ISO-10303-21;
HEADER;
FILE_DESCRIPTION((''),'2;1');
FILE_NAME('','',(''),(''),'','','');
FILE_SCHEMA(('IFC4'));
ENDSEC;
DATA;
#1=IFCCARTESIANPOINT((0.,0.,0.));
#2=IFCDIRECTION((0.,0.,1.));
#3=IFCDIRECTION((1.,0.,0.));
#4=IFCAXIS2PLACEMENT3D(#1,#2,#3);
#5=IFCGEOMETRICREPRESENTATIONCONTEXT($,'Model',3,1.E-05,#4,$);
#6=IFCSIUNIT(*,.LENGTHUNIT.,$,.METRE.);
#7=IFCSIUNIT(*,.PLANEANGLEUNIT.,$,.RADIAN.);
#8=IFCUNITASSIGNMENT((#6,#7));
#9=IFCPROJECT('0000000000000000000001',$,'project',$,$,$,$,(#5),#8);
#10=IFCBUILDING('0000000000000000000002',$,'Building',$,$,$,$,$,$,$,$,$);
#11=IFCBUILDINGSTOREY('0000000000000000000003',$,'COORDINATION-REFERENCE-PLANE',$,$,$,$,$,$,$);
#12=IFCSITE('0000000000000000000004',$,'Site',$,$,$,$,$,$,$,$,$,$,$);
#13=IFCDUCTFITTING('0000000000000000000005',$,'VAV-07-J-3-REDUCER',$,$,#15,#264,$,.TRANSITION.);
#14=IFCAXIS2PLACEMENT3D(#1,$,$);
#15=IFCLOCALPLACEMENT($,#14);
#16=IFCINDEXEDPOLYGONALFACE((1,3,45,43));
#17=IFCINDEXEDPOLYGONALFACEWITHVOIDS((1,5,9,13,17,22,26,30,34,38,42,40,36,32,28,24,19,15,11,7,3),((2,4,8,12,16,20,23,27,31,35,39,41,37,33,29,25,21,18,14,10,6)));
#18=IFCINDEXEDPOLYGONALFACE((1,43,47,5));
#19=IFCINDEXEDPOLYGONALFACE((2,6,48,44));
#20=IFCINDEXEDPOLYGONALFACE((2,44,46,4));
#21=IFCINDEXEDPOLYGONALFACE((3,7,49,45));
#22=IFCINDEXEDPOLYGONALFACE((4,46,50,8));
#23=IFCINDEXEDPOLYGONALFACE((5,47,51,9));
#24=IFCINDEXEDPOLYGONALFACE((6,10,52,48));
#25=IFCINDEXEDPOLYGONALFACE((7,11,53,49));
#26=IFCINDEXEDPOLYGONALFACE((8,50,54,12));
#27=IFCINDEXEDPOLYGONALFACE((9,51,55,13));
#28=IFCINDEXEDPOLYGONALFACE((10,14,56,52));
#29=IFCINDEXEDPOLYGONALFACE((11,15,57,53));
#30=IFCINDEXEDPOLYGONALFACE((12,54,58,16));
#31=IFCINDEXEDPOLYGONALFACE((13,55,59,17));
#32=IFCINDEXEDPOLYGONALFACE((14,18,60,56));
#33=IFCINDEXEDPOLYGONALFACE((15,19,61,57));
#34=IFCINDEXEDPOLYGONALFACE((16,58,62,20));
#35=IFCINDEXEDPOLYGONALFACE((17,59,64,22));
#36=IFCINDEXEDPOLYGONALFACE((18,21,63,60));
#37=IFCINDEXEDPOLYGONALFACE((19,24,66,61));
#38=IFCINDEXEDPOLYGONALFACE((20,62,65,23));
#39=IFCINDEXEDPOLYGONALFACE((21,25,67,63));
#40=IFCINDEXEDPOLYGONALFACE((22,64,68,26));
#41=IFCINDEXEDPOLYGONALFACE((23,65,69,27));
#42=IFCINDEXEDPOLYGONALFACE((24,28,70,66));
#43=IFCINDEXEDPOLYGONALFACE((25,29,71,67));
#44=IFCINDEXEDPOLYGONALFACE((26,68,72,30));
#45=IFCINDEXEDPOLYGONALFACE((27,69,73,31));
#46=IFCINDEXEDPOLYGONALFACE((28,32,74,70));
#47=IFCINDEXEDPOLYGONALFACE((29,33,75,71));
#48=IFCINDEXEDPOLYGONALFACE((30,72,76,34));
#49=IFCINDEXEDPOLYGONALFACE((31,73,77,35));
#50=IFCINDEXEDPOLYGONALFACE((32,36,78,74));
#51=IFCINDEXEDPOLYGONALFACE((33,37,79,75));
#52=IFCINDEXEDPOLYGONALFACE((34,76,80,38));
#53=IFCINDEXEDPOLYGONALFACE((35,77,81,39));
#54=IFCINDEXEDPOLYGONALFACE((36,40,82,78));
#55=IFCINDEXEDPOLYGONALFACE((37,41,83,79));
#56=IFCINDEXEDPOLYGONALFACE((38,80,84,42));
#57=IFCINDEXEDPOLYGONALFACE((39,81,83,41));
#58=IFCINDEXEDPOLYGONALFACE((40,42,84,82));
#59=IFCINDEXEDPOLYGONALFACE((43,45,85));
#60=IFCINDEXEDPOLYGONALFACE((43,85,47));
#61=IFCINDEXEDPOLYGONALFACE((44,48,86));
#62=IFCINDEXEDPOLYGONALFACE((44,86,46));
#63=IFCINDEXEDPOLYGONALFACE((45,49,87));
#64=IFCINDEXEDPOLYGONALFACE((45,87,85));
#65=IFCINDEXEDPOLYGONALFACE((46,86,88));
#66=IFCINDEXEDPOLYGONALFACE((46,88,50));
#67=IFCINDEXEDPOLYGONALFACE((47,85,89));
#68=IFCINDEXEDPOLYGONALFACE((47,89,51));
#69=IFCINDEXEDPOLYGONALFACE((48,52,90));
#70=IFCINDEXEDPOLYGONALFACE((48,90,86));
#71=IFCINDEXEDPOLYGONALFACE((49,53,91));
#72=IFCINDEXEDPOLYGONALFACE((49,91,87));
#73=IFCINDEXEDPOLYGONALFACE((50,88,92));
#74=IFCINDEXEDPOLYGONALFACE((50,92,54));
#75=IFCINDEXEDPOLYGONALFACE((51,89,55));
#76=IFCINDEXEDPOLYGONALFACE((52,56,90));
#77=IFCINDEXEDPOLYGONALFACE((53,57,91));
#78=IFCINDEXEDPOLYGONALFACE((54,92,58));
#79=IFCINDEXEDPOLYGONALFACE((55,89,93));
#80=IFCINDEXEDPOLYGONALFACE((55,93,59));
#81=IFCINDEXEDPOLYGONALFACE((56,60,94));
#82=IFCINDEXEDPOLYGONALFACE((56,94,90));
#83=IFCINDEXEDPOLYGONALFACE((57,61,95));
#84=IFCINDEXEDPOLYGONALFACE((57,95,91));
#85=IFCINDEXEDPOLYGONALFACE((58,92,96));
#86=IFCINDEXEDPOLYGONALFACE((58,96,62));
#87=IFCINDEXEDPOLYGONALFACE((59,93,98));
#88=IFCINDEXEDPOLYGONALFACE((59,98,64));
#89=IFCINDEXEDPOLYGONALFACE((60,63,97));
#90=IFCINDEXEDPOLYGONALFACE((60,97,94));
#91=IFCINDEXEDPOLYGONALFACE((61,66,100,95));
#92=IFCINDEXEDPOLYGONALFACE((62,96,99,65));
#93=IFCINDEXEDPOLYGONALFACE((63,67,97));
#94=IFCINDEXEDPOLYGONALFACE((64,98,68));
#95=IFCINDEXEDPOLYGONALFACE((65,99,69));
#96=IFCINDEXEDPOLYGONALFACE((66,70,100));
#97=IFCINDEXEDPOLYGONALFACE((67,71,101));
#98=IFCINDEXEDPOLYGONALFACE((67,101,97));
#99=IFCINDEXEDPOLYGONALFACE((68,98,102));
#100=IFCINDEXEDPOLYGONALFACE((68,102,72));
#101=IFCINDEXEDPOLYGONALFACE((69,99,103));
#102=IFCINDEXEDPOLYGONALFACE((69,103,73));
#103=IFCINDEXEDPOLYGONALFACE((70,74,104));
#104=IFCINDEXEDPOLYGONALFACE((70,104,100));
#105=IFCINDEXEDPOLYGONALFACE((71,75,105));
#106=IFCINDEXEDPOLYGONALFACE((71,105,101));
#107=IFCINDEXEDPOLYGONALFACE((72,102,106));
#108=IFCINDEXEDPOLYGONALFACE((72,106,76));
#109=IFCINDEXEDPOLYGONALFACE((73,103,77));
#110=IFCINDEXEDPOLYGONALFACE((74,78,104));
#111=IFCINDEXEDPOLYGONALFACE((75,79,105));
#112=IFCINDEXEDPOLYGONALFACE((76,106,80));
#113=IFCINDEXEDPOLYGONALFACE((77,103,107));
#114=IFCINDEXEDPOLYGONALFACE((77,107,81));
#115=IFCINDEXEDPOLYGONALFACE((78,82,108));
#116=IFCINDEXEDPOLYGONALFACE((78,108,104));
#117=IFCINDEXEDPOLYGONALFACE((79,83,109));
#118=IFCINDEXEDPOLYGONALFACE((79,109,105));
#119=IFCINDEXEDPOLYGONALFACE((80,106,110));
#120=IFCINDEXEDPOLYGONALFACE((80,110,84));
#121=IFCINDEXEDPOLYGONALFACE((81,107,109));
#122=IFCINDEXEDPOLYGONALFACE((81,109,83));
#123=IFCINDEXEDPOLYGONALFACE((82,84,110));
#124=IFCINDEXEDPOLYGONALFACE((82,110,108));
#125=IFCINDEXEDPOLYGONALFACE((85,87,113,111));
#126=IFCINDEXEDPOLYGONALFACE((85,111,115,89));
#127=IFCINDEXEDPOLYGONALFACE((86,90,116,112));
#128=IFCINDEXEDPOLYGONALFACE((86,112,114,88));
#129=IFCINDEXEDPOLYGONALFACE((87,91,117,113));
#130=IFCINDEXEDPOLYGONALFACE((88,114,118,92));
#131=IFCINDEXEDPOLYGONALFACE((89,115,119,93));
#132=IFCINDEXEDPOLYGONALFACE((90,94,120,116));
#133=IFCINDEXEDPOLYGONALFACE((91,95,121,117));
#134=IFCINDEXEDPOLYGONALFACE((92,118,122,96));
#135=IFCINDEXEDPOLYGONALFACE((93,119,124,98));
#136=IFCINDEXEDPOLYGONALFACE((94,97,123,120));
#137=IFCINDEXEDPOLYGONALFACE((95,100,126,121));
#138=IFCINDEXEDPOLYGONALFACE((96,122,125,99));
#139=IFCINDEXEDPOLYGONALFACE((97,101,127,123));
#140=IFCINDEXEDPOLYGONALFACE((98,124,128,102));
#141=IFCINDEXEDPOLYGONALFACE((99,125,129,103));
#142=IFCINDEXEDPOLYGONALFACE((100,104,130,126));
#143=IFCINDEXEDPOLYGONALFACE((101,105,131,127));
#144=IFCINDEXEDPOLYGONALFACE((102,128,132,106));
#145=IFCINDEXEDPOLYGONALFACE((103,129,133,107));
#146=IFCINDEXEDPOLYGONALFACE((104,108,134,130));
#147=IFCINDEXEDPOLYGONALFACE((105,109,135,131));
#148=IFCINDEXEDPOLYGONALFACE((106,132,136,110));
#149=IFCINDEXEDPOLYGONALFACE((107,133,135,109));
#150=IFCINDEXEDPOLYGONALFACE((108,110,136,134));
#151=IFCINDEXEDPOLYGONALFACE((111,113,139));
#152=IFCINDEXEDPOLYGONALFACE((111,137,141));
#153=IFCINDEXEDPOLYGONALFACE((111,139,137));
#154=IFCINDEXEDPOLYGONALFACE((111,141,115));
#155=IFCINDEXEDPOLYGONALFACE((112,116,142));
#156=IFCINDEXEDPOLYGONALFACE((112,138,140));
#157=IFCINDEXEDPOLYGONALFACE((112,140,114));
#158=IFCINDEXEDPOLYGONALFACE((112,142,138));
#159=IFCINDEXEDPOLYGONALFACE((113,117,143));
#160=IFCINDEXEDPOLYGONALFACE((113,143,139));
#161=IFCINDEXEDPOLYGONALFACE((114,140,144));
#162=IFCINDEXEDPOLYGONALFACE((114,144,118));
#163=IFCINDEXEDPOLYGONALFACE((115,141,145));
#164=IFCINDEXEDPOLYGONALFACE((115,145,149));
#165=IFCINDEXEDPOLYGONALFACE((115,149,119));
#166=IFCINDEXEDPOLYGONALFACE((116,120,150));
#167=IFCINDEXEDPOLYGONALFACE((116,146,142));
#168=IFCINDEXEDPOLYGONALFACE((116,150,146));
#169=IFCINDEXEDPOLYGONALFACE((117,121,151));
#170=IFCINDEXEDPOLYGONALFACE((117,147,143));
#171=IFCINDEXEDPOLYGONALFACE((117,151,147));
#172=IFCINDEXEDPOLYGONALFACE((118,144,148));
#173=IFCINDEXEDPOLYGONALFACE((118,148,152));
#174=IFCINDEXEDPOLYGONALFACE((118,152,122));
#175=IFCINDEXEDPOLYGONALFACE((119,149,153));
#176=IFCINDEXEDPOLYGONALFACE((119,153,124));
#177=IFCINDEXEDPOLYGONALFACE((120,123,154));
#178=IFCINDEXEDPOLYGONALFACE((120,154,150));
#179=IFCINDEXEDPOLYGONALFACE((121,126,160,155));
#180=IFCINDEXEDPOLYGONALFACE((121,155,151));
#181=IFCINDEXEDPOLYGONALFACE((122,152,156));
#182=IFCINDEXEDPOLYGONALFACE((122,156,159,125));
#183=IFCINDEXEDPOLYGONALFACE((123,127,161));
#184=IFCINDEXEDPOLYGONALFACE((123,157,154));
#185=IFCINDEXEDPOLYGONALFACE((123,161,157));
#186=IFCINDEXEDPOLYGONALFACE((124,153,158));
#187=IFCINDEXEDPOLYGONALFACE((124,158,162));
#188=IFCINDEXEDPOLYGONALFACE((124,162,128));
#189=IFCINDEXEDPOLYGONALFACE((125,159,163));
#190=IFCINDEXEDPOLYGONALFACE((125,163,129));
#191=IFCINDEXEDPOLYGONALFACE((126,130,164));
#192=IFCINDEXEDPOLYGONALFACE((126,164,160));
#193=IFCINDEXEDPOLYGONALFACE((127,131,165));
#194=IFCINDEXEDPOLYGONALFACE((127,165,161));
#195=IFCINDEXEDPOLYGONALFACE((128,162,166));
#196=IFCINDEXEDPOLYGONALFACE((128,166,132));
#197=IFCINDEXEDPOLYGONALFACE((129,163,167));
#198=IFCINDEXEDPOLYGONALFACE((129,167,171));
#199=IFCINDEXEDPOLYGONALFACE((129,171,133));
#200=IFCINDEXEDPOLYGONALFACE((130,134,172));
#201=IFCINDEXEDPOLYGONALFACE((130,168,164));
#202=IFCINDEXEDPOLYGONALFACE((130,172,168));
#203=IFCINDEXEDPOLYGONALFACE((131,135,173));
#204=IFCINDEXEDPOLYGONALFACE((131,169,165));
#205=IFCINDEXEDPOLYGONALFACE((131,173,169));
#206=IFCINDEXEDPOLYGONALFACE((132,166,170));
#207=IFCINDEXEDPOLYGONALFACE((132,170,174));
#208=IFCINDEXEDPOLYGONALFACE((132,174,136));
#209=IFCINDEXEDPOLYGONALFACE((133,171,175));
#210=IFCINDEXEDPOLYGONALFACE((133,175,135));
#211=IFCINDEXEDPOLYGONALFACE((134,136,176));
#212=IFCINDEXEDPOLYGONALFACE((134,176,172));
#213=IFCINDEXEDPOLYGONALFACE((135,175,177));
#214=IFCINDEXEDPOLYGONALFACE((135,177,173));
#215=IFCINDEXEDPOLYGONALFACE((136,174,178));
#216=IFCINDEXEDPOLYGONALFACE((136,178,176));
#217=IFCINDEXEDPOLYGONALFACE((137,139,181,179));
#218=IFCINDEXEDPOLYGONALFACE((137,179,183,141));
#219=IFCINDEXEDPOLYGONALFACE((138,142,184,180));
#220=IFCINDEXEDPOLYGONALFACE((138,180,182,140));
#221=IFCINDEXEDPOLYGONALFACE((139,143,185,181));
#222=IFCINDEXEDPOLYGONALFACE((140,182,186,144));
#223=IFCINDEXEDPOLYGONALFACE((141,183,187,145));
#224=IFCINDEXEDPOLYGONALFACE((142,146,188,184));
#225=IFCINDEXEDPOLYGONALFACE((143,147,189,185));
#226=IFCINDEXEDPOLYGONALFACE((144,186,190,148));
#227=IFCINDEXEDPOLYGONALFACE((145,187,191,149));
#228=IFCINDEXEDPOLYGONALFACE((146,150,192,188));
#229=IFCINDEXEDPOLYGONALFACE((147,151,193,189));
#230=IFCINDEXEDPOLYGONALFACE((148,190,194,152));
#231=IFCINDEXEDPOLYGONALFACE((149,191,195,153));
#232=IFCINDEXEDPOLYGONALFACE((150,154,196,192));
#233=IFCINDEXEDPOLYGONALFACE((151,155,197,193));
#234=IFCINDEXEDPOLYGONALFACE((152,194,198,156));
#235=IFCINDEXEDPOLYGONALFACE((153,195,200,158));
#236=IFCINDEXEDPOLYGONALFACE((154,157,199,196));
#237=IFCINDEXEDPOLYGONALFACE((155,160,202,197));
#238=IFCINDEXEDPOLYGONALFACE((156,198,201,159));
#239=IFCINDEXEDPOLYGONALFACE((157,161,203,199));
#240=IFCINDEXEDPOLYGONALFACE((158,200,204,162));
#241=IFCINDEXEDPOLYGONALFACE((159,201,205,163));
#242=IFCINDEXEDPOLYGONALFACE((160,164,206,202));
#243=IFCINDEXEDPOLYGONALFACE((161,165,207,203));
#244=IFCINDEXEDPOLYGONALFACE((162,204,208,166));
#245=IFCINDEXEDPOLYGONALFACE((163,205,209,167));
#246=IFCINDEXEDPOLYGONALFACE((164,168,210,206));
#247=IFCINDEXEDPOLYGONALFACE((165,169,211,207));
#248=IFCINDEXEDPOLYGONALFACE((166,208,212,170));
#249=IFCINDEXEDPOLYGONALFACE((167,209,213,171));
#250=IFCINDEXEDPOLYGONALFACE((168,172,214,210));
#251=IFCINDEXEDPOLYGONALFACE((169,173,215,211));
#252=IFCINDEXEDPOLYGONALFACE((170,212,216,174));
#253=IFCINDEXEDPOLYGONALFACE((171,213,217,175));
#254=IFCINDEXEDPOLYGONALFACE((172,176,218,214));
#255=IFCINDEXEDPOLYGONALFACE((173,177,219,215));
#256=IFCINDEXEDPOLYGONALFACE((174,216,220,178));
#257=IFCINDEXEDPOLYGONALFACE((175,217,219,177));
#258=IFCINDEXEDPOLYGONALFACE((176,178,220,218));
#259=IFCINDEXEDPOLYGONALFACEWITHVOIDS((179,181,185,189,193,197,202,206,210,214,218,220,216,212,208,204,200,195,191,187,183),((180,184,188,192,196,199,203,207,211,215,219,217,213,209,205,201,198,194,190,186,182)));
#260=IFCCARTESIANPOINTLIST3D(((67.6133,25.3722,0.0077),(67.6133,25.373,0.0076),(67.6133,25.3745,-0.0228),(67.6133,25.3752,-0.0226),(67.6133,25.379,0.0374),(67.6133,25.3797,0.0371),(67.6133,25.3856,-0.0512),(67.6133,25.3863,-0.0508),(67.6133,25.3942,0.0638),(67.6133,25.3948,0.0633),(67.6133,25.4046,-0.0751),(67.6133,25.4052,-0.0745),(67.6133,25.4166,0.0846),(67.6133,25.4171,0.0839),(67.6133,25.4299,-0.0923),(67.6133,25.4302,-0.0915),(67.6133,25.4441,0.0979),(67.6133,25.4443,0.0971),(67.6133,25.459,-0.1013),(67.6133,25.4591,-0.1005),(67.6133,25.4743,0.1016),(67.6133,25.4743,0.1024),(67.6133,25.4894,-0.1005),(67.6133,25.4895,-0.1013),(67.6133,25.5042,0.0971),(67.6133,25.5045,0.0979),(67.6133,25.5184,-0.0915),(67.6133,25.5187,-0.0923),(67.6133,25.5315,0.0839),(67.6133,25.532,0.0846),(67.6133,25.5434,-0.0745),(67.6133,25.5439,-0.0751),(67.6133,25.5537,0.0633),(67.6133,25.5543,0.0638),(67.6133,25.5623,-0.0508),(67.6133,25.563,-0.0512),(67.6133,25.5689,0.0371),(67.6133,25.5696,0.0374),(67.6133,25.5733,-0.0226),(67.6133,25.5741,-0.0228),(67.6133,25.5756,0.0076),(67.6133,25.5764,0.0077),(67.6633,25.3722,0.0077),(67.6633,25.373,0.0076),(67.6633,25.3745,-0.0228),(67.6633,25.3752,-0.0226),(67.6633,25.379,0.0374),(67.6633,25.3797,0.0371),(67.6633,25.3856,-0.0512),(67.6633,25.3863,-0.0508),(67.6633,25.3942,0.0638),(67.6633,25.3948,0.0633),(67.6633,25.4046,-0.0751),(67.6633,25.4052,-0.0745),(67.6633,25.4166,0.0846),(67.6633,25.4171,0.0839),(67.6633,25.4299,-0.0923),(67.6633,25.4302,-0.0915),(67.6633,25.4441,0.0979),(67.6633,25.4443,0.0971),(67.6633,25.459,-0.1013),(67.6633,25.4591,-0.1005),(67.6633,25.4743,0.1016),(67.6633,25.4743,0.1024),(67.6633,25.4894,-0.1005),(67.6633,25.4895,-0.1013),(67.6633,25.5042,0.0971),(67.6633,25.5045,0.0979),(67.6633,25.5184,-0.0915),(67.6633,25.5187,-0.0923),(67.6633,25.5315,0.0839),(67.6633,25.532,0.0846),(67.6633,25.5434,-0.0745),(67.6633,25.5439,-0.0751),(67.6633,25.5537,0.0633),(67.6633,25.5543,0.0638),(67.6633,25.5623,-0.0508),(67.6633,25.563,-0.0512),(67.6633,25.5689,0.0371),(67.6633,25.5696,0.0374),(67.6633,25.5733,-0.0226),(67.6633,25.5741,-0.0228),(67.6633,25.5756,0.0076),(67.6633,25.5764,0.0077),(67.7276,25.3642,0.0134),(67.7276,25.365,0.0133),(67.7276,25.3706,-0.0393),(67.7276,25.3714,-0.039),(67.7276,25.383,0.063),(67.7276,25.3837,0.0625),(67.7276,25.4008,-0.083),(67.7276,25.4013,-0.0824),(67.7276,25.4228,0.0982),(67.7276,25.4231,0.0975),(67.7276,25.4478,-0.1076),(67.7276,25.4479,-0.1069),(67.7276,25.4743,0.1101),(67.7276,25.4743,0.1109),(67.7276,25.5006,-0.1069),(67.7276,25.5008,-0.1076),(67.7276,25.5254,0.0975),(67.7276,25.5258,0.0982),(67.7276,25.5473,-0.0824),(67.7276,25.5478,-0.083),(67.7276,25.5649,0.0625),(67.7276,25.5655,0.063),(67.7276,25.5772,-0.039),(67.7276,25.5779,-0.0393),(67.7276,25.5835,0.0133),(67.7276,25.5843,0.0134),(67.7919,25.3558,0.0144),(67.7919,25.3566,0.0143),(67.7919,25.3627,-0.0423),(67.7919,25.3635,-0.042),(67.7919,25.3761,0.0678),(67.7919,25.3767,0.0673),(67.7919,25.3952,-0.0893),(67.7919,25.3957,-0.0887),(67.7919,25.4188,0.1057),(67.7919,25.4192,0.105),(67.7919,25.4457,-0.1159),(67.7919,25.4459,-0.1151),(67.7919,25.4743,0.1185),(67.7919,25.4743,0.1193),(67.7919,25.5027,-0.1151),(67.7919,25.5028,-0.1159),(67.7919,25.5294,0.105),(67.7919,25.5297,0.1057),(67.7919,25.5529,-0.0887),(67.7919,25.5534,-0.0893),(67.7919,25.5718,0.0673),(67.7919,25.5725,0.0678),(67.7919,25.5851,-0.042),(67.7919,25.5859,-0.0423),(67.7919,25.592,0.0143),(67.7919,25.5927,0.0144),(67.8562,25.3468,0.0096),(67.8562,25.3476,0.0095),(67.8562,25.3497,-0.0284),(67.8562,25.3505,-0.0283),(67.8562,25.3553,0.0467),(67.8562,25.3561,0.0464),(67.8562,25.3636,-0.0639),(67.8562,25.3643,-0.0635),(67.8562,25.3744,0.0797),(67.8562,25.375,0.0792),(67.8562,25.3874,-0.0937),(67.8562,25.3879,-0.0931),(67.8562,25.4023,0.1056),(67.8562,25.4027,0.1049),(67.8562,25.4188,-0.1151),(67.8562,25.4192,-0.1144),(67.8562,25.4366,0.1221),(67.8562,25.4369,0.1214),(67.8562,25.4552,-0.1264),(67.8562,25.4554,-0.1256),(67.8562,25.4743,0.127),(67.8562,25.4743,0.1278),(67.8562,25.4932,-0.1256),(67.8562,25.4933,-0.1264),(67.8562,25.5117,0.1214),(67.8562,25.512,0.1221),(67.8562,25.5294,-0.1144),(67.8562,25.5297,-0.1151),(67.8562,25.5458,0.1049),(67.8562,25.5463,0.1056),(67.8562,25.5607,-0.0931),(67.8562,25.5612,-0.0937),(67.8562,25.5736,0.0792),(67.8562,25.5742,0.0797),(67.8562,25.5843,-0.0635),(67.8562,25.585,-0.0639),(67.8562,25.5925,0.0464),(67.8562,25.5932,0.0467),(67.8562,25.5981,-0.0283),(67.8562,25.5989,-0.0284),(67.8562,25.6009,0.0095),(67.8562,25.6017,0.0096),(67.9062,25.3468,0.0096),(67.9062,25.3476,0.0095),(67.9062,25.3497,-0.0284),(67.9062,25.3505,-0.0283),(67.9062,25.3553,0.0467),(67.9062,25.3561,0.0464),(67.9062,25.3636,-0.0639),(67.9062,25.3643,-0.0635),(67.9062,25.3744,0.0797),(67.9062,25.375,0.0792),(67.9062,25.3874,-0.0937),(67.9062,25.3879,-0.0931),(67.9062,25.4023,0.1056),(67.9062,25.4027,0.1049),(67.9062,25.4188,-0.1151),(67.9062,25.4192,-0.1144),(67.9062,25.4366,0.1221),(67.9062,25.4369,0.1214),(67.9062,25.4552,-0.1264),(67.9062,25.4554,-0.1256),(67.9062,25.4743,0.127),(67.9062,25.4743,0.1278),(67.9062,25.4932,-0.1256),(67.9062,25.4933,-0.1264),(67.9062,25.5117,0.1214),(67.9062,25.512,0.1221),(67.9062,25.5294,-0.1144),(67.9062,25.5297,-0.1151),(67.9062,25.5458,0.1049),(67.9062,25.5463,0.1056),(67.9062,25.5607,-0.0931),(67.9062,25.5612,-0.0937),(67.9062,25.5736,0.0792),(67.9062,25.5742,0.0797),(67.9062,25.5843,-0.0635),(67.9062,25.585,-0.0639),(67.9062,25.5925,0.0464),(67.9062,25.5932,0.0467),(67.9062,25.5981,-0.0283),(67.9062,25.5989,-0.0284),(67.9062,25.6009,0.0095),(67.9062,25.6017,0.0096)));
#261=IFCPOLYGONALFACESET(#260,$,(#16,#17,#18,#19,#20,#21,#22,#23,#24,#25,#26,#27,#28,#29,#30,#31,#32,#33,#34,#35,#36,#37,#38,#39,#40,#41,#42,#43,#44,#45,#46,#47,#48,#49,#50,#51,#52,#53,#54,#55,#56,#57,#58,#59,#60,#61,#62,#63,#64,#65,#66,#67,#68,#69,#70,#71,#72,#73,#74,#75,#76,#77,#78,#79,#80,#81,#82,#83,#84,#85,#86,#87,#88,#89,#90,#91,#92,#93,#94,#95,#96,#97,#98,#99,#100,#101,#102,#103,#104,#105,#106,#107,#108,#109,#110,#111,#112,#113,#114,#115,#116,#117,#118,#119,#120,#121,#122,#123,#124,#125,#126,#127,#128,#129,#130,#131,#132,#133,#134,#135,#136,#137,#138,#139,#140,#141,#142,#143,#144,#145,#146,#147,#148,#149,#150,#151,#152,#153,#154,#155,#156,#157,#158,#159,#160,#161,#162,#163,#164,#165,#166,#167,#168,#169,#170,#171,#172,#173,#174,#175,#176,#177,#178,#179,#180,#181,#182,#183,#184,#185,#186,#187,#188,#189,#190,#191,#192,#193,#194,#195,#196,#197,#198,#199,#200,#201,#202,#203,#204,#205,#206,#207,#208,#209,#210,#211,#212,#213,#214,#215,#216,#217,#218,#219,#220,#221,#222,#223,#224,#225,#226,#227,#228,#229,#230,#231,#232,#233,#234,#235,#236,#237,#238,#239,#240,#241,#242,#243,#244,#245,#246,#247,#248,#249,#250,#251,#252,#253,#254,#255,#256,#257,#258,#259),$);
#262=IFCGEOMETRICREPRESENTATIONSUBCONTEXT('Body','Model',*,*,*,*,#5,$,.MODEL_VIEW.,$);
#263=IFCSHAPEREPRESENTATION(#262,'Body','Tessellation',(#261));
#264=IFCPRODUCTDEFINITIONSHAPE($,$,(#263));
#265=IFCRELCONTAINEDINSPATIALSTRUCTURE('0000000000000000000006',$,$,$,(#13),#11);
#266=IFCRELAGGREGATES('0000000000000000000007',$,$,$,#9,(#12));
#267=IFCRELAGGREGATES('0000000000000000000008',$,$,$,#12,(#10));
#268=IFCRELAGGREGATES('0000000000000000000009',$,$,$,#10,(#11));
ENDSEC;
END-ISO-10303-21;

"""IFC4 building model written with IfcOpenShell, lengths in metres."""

from ifc_helpers import new_model, entity, si_unit, frame, origin_with_axes, place, context, subcontext, project, spatial, element, save


model = new_model("IFC4")

# Units and contexts
model_context = context("Model", 3, precision=1e-05, world=origin_with_axes())
body_context_1 = subcontext(model_context, "Body", "Model", "MODEL_VIEW")
ifc_project = project(units=[si_unit("LENGTHUNIT", "METRE"), si_unit("PLANEANGLEUNIT", "RADIAN")], contexts=[model_context])

# Site, building, storey
site = spatial("IfcSite", under=ifc_project, Name="Site")
building = spatial("IfcBuilding", under=site, Name="Building")
storey = spatial("IfcBuildingStorey", under=building, Name="COORDINATION-REFERENCE-PLANE")

# Duct fitting
for number, where, z_axis, x_axis, name in (
    (1, (67.9062, 25.4743, 0.0), (0.0, -1.0, 0.0), (0.0, 0.0, 1.0), "VAV-07-J-3-REDUCER"),
):
    element("IfcDuctFitting", number, at=place(None, frame(where, z_axis=z_axis, x_axis=x_axis)), inside=storey, Name=name, PredefinedType="TRANSITION", context=body_context_1, shape_type="SweptSolid", body=[
        entity("IfcRevolvedAreaSolid", entity("IfcArbitraryClosedProfileDef", "AREA", None, entity("IfcPolyline", [entity("IfcCartesianPoint", [0.1278, 0.0]), entity("IfcCartesianPoint", [0.1278, 0.05]), entity("IfcCartesianPoint", [0.1024, 0.2429]), entity("IfcCartesianPoint", [0.1024, 0.2929]), entity("IfcCartesianPoint", [0.1016, 0.2929]), entity("IfcCartesianPoint", [0.1016, 0.2429]), entity("IfcCartesianPoint", [0.127, 0.05]), entity("IfcCartesianPoint", [0.127, 0.0]), entity("IfcCartesianPoint", [0.1278, 0.0])])), entity("IfcAxis2Placement3D", entity("IfcCartesianPoint", [0.0, 0.0, 0.0])), entity("IfcAxis1Placement", entity("IfcCartesianPoint", [0.0, 0.0, 0.0]), entity("IfcDirection", [0.0, 1.0, 0.0])), 6.283185),
    ])

save(model, "model.ifc")
